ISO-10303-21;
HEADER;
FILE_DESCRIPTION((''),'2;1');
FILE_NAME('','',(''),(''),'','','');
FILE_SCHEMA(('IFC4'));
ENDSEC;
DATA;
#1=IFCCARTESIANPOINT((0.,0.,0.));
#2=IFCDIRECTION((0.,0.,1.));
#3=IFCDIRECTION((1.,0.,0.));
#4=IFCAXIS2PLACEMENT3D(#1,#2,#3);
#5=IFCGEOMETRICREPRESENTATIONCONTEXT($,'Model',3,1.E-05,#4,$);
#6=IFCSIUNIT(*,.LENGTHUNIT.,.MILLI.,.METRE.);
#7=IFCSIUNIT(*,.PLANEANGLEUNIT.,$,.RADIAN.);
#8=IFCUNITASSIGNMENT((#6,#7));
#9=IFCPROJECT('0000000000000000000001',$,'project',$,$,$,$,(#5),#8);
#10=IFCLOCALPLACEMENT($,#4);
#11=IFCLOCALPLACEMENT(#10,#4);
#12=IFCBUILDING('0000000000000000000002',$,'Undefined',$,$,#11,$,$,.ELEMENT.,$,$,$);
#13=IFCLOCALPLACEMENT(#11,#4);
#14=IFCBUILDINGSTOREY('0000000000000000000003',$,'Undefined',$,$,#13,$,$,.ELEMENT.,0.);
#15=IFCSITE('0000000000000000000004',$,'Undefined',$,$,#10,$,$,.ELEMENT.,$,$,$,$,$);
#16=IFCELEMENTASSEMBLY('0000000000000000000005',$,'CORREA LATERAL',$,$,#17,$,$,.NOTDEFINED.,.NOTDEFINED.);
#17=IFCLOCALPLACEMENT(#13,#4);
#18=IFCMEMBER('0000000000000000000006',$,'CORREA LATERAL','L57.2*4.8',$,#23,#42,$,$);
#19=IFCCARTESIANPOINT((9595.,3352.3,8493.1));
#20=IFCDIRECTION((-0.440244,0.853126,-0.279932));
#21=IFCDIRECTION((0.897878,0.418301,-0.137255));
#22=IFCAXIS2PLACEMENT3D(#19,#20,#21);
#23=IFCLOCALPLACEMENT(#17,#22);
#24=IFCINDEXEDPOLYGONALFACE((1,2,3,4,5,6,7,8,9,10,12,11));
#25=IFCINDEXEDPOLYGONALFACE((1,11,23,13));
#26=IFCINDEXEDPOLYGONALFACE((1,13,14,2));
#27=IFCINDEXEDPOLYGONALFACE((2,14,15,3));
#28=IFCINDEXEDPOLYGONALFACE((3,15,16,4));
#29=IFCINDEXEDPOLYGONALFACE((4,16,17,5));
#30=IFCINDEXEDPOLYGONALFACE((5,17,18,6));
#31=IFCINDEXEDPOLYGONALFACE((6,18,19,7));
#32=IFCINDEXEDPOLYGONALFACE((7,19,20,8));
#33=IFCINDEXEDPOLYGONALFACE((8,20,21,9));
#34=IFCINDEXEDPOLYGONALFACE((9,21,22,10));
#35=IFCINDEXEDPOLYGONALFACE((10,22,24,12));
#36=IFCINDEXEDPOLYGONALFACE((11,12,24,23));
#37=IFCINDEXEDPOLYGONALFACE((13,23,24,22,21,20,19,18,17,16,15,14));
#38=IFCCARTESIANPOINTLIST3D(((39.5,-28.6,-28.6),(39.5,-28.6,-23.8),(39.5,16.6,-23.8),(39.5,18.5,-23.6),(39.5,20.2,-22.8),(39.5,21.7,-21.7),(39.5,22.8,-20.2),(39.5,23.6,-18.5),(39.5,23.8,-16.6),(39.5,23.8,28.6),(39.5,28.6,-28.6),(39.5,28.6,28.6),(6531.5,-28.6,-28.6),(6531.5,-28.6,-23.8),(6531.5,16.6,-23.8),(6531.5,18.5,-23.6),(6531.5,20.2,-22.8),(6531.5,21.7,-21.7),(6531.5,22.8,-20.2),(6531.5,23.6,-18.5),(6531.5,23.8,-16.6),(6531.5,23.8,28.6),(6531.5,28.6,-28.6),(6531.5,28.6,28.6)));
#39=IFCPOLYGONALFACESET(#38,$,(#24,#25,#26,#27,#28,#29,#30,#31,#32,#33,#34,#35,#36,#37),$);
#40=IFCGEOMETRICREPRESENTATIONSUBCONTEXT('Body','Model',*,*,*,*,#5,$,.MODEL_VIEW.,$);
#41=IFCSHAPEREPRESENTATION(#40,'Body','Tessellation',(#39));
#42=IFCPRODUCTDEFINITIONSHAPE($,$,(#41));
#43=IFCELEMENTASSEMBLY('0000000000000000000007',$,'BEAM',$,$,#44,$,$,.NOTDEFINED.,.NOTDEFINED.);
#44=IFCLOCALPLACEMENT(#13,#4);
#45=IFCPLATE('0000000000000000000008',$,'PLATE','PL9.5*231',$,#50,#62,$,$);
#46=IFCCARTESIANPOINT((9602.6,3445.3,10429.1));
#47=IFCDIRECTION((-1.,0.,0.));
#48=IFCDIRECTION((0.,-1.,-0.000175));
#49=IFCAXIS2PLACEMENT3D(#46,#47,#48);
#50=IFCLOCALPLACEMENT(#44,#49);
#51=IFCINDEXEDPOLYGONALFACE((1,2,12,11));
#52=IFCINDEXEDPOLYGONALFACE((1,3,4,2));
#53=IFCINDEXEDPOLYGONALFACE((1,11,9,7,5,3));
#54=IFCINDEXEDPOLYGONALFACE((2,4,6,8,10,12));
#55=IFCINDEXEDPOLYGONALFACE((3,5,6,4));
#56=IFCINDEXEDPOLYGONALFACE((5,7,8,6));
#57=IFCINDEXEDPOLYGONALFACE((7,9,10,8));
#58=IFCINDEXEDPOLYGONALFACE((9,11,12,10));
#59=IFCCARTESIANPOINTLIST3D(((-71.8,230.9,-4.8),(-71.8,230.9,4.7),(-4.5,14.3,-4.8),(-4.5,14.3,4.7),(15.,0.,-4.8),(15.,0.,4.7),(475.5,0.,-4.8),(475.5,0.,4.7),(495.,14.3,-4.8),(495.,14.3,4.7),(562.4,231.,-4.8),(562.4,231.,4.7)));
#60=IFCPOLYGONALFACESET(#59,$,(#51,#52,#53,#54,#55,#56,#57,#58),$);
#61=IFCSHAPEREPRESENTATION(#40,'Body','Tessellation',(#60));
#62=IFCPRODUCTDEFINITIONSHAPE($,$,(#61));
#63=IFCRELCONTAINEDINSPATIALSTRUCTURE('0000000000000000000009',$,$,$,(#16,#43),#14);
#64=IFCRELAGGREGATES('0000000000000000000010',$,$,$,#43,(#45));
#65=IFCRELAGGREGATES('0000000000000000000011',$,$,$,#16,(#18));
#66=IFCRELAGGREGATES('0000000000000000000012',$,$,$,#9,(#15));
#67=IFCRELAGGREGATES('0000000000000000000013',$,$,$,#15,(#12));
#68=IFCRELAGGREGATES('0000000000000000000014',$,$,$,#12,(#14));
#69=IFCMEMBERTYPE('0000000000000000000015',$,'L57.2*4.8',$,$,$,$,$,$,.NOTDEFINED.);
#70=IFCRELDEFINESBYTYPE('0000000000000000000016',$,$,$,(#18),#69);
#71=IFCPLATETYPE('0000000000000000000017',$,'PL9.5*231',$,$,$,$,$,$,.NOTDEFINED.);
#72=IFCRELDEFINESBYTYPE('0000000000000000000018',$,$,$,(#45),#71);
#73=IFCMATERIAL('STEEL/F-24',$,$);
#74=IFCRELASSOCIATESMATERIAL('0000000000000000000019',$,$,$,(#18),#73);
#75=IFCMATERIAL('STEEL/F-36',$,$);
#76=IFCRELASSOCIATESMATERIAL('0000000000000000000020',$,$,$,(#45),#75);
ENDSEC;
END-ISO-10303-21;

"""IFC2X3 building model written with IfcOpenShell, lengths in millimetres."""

from ifc_helpers import new_model, si_unit, frame, origin_with_axes, origin_2d_with_axis, place, context, subcontext, project, spatial, polyline, l_section, outline, extrude, clip, halfspace, material, type_object, element, aggregate, save


model = new_model("IFC2X3")

# Units and contexts
model_context = context("Model", 3, precision=1e-05, world=origin_with_axes())
body_context = subcontext(model_context, "Body", "Model", "MODEL_VIEW")
ifc_project = project(units=[si_unit("LENGTHUNIT", "METRE", prefix="MILLI"), si_unit("PLANEANGLEUNIT", "RADIAN")], contexts=[model_context])

# Site, building, storey
site_placement = place(None, origin_with_axes())
site = spatial("IfcSite", under=ifc_project, at=site_placement, Name="Undefined", CompositionType="ELEMENT")
building_placement = place(site_placement, origin_with_axes())
building = spatial("IfcBuilding", under=site, at=building_placement, Name="Undefined", CompositionType="ELEMENT")
storey_placement = place(building_placement, origin_with_axes())
storey = spatial("IfcBuildingStorey", under=building, at=storey_placement, Name="Undefined", CompositionType="ELEMENT", Elevation=0.0)

# Shared definitions
ifc_material_1 = material(Name="STEEL/F-24")

# Element assembly, member
member_type = type_object("IfcMemberType", Name="L57.2*4.8", PredefinedType="NOTDEFINED")
assembly_1_placement = place(storey_placement, origin_with_axes())
assembly_1 = element("IfcElementAssembly", 1, at=assembly_1_placement, inside=storey, Name="CORREA LATERAL", AssemblyPlace="NOTDEFINED", PredefinedType="NOTDEFINED")
member_1_placement = place(assembly_1_placement, frame((9595.0, 3352.3, 8493.1), z_axis=(-0.440244, 0.853126, -0.279932), x_axis=(0.897878, 0.418301, -0.137255)))
member_1 = element("IfcMember", 2, at=member_1_placement, type_object=member_type, material=ifc_material_1, Name="CORREA LATERAL", Description="L57.2*4.8", context=body_context, shape_type="Clipping", body=[
    clip(clip(extrude(l_section(Depth=57.2, Width=57.2, Thickness=4.8, FilletRadius=7.2, at=origin_2d_with_axis()), frame((6585.4, 0.0, 0.0), z_axis=(-1.0, 0.0, 0.0), x_axis=(0.0, -1.0, 0.0)), (0.0, 0.0, 1.0), 6599.7), halfspace(frame((6531.5, 28.6, 0.0), z_axis=(-1.0, 0.0, 0.0), x_axis=(0.0, 0.000037, 1.0)), True)), halfspace(frame((39.5, 38.1, 0.0), z_axis=(1.0, 0.0, 0.0), x_axis=(0.0, -0.000037, -1.0)), True)),
])

# Shared definitions
ifc_material_2 = material(Name="STEEL/F-36")

# Element assembly, plate
assembly_2_placement = place(storey_placement, origin_with_axes())
assembly_2 = element("IfcElementAssembly", 3, at=assembly_2_placement, inside=storey, Name="BEAM", AssemblyPlace="NOTDEFINED", PredefinedType="NOTDEFINED")
plate_type_1 = type_object("IfcPlateType", Name="PL9.5*231", PredefinedType="NOTDEFINED")
plate_1_placement = place(assembly_2_placement, frame((9602.6, 3445.3, 10429.1), z_axis=(-1.0, 0.0, 0.0), x_axis=(0.0, -1.0, -0.000175)))
plate_1 = element("IfcPlate", 4, at=plate_1_placement, type_object=plate_type_1, material=ifc_material_2, Name="PLATE", Description="PL9.5*231", context=body_context, shape_type="SweptSolid", body=[
    extrude(outline(polyline([(-4.5, 14.3), (15.0, 0.0), (475.5, 0.0), (495.0, 14.3), (562.4, 231.0), (-71.8, 230.9), (-4.5, 14.3)])), frame((0.0, 0.0, -4.8), z_axis=(0.0, 0.0, 1.0), x_axis=(1.0, 0.0, 0.0)), (0.0, 0.0, 1.0), 9.5),
])

aggregate(assembly_2, [plate_1])

aggregate(assembly_1, [member_1])

save(model, "model.ifc")
